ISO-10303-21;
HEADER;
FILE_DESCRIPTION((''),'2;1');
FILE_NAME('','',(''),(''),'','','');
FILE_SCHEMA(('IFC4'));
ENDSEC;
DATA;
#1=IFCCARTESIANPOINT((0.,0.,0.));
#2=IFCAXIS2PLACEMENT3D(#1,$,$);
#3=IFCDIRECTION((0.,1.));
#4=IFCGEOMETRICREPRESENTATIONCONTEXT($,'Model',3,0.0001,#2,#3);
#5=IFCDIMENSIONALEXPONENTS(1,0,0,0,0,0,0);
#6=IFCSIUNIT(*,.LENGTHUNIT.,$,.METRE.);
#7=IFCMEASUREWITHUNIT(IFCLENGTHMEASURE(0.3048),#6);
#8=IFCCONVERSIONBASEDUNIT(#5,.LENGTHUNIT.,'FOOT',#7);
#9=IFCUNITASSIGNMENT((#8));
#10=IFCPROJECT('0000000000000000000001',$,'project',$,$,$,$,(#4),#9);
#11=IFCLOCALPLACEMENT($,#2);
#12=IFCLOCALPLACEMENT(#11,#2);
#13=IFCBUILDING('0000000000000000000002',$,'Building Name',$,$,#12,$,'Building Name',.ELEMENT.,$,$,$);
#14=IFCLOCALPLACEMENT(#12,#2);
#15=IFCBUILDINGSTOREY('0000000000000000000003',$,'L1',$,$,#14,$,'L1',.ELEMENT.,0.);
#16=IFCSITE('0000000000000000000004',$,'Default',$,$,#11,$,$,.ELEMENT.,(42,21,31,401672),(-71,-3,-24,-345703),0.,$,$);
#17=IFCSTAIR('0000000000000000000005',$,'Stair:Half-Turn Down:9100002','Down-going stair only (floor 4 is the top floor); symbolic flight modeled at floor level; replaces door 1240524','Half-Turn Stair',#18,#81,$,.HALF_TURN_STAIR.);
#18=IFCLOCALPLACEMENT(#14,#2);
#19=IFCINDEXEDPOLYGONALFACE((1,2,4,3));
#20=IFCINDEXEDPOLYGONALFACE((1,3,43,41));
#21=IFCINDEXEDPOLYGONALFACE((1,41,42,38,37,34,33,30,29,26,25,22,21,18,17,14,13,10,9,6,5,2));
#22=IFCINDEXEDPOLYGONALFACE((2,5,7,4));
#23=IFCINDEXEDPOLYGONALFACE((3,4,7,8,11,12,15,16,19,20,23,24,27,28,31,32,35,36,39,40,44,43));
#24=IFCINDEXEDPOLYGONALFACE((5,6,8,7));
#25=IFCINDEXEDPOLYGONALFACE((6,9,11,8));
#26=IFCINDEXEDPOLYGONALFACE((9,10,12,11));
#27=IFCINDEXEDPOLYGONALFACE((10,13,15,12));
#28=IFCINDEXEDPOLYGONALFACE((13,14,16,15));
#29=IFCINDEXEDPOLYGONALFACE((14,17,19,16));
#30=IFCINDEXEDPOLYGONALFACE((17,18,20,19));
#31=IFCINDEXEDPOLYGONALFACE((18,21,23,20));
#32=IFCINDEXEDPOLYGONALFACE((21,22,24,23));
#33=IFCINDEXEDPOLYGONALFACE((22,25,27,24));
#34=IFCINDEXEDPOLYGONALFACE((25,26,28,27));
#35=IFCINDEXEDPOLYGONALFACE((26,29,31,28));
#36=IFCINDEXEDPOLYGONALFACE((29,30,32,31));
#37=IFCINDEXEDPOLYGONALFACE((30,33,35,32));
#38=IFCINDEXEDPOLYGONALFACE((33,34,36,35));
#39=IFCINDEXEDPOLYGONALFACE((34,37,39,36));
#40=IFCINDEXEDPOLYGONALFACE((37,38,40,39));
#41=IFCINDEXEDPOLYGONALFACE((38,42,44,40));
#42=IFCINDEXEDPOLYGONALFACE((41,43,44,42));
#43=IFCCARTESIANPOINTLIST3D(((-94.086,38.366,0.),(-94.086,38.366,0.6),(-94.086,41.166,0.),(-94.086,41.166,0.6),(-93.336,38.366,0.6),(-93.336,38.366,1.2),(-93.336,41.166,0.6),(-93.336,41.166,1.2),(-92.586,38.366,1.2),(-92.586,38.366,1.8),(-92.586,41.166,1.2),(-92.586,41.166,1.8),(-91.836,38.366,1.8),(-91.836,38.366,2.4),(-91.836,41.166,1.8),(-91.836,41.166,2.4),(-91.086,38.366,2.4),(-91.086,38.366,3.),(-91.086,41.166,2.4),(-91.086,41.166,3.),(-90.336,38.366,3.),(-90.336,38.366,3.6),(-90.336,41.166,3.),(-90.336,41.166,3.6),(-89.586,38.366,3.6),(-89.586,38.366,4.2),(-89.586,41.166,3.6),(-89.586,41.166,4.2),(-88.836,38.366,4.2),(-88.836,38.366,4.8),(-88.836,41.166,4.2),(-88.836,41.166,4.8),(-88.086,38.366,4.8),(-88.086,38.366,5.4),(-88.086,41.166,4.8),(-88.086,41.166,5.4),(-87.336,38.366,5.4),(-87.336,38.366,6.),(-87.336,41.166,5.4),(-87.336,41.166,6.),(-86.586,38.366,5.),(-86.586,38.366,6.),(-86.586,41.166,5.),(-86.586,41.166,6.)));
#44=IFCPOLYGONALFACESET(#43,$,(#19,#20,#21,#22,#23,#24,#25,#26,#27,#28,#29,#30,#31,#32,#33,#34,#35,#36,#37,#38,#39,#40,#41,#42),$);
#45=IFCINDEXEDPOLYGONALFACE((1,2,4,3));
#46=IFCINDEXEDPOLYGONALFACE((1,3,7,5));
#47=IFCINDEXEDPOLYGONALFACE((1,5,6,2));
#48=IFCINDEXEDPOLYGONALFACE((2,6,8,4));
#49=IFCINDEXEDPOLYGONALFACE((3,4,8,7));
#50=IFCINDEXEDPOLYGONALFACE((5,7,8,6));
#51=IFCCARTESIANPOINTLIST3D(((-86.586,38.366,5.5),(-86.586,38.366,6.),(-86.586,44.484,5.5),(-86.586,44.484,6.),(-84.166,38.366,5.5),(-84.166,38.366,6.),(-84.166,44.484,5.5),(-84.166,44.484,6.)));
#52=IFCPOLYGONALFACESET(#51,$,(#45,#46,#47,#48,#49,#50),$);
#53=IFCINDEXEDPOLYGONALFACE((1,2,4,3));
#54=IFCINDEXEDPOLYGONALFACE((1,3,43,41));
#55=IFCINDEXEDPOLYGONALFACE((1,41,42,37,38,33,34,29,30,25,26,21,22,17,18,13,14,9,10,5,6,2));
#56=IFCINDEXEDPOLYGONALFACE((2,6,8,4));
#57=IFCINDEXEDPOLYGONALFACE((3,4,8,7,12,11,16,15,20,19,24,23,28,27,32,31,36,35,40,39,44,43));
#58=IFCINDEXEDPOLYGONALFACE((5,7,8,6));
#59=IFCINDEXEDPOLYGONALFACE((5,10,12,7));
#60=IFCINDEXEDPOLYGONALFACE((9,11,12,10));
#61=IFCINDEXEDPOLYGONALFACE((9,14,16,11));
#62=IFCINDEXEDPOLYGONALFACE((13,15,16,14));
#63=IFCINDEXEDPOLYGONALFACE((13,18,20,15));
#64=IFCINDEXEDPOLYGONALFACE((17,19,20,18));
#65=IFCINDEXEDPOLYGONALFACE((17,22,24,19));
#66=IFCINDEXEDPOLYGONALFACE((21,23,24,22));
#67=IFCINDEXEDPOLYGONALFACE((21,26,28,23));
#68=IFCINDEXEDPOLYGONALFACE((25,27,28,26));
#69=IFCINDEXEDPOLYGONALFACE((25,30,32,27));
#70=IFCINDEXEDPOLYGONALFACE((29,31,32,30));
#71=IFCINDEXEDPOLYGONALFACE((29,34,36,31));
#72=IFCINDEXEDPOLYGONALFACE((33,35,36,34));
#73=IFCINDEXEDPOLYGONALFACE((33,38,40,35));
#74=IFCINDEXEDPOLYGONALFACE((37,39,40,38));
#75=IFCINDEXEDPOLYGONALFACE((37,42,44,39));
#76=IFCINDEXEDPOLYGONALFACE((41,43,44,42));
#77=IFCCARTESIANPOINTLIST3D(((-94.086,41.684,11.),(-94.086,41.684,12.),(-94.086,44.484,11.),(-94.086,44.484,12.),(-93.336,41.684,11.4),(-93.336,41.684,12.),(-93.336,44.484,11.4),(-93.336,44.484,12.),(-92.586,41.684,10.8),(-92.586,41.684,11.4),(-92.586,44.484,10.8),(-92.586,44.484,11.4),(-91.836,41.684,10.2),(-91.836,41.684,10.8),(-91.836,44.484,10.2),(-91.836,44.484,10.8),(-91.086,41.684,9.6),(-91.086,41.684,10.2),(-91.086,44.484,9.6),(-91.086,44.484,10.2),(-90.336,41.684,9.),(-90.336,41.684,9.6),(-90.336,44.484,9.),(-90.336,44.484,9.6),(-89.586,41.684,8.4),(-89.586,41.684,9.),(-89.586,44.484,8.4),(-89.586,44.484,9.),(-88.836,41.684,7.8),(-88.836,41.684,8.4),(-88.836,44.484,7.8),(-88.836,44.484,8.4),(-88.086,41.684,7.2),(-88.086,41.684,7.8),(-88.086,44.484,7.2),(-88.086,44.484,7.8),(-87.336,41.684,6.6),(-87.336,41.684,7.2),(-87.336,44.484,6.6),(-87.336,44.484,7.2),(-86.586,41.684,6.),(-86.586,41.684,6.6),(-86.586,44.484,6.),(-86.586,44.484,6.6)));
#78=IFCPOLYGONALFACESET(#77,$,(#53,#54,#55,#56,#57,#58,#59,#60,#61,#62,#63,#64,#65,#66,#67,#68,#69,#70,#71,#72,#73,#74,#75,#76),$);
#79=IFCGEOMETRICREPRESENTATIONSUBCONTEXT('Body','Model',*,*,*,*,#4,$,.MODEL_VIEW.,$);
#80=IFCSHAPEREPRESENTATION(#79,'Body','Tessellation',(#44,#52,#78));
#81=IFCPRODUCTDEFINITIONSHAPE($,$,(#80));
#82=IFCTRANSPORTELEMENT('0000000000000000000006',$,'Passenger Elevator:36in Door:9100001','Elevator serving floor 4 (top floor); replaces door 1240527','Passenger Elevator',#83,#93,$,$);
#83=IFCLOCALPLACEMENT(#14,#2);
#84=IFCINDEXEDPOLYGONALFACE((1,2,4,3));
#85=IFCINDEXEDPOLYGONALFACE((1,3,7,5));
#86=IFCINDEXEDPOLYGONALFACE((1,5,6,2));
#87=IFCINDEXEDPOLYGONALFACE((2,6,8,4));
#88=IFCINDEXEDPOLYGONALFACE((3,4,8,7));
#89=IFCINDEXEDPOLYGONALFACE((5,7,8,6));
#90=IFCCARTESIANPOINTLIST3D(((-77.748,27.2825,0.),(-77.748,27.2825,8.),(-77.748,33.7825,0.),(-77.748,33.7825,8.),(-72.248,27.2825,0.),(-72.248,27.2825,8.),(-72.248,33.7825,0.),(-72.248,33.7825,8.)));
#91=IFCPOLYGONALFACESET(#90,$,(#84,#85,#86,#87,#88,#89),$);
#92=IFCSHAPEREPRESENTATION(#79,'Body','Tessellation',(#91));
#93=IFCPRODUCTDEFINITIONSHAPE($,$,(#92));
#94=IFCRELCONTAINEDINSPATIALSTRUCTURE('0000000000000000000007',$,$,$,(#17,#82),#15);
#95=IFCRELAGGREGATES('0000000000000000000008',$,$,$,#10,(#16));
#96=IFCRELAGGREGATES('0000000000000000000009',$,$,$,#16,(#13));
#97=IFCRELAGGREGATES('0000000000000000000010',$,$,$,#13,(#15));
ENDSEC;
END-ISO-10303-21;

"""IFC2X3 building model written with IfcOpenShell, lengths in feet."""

from ifc_helpers import new_model, entity, si_unit, converted_unit, direction, frame, frame_2d, origin, place, context, subcontext, project, spatial, polyline, rectangle, outline, extrude, element, save


model = new_model("IFC2X3")

# Units and contexts
model_context = context("Model", 3, precision=0.0001, world=origin(), true_north=direction((0.0, 1.0)))
body_context = subcontext(model_context, "Body", "Model", "MODEL_VIEW")
ifc_project = project(units=[converted_unit("LENGTHUNIT", "FOOT", entity("IfcLengthMeasure", 0.3048), si_unit("LENGTHUNIT", "METRE"), dimensions=[1, 0, 0, 0, 0, 0, 0])], contexts=[model_context])

# Site, building, storey
site_placement = place(None, origin())
site = spatial("IfcSite", under=ifc_project, at=site_placement, Name="Default", CompositionType="ELEMENT", RefLatitude=(42, 21, 31, 401672), RefLongitude=(-71, -3, -24, -345703), RefElevation=0.0)
building_placement = place(site_placement, origin())
building = spatial("IfcBuilding", under=site, at=building_placement, Name="Building Name", LongName="Building Name", CompositionType="ELEMENT")
storey_placement = place(building_placement, origin())
storey = spatial("IfcBuildingStorey", under=building, at=storey_placement, Name="L1", LongName="L1", CompositionType="ELEMENT", Elevation=0.0)

# Stair
stair_placement = place(storey_placement, frame((-94.086, 38.366, 0.0), z_axis=(0.0, 0.0, 1.0), x_axis=(1.0, 0.0, 0.0)))
element("IfcStair", 1, at=stair_placement, inside=storey, Name="Stair:Half-Turn Down:9100002", Description="Down-going stair only (floor 4 is the top floor); symbolic flight modeled at floor level; replaces door 1240524", ObjectType="Half-Turn Stair", ShapeType="HALF_TURN_STAIR", context=body_context, shape_type="SweptSolid", body=[
    extrude(outline(polyline([(0.0, 0.0), (0.0, 0.6), (0.75, 0.6), (0.75, 1.2), (1.5, 1.2), (1.5, 1.8), (2.25, 1.8), (2.25, 2.4), (3.0, 2.4), (3.0, 3.0), (3.75, 3.0), (3.75, 3.6), (4.5, 3.6), (4.5, 4.2), (5.25, 4.2), (5.25, 4.8), (6.0, 4.8), (6.0, 5.4), (6.75, 5.4), (6.75, 6.0), (7.5, 6.0), (7.5, 5.0), (0.0, 0.0)])), frame((0.0, 2.8, 0.0), z_axis=(0.0, -1.0, 0.0), x_axis=(1.0, 0.0, 0.0)), (0.0, 0.0, 1.0), 2.8),
    extrude(rectangle(XDim=2.42, YDim=6.118, at=frame_2d((8.71, 3.059))), frame((0.0, 0.0, 5.5)), (0.0, 0.0, 1.0), 0.5),
    extrude(outline(polyline([(0.0, 0.0), (0.0, 0.6), (0.75, 0.6), (0.75, 1.2), (1.5, 1.2), (1.5, 1.8), (2.25, 1.8), (2.25, 2.4), (3.0, 2.4), (3.0, 3.0), (3.75, 3.0), (3.75, 3.6), (4.5, 3.6), (4.5, 4.2), (5.25, 4.2), (5.25, 4.8), (6.0, 4.8), (6.0, 5.4), (6.75, 5.4), (6.75, 6.0), (7.5, 6.0), (7.5, 5.0), (0.0, 0.0)])), frame((7.5, 3.318, 6.0), z_axis=(0.0, 1.0, 0.0), x_axis=(-1.0, 0.0, 0.0)), (0.0, 0.0, 1.0), 2.8),
])

# Transport element
transport_element_placement = place(storey_placement, frame((-77.748, 30.5325, 0.0), z_axis=(0.0, 0.0, 1.0), x_axis=(1.0, 0.0, 0.0)))
element("IfcTransportElement", 2, at=transport_element_placement, inside=storey, Name="Passenger Elevator:36in Door:9100001", Description="Elevator serving floor 4 (top floor); replaces door 1240527", ObjectType="Passenger Elevator", OperationType="ELEVATOR", context=body_context, shape_type="SweptSolid", body=[
    extrude(rectangle(XDim=5.5, YDim=6.5, at=frame_2d((2.75, 0.0))), origin(), (0.0, 0.0, 1.0), 8.0),
])

save(model, "model.ifc")
